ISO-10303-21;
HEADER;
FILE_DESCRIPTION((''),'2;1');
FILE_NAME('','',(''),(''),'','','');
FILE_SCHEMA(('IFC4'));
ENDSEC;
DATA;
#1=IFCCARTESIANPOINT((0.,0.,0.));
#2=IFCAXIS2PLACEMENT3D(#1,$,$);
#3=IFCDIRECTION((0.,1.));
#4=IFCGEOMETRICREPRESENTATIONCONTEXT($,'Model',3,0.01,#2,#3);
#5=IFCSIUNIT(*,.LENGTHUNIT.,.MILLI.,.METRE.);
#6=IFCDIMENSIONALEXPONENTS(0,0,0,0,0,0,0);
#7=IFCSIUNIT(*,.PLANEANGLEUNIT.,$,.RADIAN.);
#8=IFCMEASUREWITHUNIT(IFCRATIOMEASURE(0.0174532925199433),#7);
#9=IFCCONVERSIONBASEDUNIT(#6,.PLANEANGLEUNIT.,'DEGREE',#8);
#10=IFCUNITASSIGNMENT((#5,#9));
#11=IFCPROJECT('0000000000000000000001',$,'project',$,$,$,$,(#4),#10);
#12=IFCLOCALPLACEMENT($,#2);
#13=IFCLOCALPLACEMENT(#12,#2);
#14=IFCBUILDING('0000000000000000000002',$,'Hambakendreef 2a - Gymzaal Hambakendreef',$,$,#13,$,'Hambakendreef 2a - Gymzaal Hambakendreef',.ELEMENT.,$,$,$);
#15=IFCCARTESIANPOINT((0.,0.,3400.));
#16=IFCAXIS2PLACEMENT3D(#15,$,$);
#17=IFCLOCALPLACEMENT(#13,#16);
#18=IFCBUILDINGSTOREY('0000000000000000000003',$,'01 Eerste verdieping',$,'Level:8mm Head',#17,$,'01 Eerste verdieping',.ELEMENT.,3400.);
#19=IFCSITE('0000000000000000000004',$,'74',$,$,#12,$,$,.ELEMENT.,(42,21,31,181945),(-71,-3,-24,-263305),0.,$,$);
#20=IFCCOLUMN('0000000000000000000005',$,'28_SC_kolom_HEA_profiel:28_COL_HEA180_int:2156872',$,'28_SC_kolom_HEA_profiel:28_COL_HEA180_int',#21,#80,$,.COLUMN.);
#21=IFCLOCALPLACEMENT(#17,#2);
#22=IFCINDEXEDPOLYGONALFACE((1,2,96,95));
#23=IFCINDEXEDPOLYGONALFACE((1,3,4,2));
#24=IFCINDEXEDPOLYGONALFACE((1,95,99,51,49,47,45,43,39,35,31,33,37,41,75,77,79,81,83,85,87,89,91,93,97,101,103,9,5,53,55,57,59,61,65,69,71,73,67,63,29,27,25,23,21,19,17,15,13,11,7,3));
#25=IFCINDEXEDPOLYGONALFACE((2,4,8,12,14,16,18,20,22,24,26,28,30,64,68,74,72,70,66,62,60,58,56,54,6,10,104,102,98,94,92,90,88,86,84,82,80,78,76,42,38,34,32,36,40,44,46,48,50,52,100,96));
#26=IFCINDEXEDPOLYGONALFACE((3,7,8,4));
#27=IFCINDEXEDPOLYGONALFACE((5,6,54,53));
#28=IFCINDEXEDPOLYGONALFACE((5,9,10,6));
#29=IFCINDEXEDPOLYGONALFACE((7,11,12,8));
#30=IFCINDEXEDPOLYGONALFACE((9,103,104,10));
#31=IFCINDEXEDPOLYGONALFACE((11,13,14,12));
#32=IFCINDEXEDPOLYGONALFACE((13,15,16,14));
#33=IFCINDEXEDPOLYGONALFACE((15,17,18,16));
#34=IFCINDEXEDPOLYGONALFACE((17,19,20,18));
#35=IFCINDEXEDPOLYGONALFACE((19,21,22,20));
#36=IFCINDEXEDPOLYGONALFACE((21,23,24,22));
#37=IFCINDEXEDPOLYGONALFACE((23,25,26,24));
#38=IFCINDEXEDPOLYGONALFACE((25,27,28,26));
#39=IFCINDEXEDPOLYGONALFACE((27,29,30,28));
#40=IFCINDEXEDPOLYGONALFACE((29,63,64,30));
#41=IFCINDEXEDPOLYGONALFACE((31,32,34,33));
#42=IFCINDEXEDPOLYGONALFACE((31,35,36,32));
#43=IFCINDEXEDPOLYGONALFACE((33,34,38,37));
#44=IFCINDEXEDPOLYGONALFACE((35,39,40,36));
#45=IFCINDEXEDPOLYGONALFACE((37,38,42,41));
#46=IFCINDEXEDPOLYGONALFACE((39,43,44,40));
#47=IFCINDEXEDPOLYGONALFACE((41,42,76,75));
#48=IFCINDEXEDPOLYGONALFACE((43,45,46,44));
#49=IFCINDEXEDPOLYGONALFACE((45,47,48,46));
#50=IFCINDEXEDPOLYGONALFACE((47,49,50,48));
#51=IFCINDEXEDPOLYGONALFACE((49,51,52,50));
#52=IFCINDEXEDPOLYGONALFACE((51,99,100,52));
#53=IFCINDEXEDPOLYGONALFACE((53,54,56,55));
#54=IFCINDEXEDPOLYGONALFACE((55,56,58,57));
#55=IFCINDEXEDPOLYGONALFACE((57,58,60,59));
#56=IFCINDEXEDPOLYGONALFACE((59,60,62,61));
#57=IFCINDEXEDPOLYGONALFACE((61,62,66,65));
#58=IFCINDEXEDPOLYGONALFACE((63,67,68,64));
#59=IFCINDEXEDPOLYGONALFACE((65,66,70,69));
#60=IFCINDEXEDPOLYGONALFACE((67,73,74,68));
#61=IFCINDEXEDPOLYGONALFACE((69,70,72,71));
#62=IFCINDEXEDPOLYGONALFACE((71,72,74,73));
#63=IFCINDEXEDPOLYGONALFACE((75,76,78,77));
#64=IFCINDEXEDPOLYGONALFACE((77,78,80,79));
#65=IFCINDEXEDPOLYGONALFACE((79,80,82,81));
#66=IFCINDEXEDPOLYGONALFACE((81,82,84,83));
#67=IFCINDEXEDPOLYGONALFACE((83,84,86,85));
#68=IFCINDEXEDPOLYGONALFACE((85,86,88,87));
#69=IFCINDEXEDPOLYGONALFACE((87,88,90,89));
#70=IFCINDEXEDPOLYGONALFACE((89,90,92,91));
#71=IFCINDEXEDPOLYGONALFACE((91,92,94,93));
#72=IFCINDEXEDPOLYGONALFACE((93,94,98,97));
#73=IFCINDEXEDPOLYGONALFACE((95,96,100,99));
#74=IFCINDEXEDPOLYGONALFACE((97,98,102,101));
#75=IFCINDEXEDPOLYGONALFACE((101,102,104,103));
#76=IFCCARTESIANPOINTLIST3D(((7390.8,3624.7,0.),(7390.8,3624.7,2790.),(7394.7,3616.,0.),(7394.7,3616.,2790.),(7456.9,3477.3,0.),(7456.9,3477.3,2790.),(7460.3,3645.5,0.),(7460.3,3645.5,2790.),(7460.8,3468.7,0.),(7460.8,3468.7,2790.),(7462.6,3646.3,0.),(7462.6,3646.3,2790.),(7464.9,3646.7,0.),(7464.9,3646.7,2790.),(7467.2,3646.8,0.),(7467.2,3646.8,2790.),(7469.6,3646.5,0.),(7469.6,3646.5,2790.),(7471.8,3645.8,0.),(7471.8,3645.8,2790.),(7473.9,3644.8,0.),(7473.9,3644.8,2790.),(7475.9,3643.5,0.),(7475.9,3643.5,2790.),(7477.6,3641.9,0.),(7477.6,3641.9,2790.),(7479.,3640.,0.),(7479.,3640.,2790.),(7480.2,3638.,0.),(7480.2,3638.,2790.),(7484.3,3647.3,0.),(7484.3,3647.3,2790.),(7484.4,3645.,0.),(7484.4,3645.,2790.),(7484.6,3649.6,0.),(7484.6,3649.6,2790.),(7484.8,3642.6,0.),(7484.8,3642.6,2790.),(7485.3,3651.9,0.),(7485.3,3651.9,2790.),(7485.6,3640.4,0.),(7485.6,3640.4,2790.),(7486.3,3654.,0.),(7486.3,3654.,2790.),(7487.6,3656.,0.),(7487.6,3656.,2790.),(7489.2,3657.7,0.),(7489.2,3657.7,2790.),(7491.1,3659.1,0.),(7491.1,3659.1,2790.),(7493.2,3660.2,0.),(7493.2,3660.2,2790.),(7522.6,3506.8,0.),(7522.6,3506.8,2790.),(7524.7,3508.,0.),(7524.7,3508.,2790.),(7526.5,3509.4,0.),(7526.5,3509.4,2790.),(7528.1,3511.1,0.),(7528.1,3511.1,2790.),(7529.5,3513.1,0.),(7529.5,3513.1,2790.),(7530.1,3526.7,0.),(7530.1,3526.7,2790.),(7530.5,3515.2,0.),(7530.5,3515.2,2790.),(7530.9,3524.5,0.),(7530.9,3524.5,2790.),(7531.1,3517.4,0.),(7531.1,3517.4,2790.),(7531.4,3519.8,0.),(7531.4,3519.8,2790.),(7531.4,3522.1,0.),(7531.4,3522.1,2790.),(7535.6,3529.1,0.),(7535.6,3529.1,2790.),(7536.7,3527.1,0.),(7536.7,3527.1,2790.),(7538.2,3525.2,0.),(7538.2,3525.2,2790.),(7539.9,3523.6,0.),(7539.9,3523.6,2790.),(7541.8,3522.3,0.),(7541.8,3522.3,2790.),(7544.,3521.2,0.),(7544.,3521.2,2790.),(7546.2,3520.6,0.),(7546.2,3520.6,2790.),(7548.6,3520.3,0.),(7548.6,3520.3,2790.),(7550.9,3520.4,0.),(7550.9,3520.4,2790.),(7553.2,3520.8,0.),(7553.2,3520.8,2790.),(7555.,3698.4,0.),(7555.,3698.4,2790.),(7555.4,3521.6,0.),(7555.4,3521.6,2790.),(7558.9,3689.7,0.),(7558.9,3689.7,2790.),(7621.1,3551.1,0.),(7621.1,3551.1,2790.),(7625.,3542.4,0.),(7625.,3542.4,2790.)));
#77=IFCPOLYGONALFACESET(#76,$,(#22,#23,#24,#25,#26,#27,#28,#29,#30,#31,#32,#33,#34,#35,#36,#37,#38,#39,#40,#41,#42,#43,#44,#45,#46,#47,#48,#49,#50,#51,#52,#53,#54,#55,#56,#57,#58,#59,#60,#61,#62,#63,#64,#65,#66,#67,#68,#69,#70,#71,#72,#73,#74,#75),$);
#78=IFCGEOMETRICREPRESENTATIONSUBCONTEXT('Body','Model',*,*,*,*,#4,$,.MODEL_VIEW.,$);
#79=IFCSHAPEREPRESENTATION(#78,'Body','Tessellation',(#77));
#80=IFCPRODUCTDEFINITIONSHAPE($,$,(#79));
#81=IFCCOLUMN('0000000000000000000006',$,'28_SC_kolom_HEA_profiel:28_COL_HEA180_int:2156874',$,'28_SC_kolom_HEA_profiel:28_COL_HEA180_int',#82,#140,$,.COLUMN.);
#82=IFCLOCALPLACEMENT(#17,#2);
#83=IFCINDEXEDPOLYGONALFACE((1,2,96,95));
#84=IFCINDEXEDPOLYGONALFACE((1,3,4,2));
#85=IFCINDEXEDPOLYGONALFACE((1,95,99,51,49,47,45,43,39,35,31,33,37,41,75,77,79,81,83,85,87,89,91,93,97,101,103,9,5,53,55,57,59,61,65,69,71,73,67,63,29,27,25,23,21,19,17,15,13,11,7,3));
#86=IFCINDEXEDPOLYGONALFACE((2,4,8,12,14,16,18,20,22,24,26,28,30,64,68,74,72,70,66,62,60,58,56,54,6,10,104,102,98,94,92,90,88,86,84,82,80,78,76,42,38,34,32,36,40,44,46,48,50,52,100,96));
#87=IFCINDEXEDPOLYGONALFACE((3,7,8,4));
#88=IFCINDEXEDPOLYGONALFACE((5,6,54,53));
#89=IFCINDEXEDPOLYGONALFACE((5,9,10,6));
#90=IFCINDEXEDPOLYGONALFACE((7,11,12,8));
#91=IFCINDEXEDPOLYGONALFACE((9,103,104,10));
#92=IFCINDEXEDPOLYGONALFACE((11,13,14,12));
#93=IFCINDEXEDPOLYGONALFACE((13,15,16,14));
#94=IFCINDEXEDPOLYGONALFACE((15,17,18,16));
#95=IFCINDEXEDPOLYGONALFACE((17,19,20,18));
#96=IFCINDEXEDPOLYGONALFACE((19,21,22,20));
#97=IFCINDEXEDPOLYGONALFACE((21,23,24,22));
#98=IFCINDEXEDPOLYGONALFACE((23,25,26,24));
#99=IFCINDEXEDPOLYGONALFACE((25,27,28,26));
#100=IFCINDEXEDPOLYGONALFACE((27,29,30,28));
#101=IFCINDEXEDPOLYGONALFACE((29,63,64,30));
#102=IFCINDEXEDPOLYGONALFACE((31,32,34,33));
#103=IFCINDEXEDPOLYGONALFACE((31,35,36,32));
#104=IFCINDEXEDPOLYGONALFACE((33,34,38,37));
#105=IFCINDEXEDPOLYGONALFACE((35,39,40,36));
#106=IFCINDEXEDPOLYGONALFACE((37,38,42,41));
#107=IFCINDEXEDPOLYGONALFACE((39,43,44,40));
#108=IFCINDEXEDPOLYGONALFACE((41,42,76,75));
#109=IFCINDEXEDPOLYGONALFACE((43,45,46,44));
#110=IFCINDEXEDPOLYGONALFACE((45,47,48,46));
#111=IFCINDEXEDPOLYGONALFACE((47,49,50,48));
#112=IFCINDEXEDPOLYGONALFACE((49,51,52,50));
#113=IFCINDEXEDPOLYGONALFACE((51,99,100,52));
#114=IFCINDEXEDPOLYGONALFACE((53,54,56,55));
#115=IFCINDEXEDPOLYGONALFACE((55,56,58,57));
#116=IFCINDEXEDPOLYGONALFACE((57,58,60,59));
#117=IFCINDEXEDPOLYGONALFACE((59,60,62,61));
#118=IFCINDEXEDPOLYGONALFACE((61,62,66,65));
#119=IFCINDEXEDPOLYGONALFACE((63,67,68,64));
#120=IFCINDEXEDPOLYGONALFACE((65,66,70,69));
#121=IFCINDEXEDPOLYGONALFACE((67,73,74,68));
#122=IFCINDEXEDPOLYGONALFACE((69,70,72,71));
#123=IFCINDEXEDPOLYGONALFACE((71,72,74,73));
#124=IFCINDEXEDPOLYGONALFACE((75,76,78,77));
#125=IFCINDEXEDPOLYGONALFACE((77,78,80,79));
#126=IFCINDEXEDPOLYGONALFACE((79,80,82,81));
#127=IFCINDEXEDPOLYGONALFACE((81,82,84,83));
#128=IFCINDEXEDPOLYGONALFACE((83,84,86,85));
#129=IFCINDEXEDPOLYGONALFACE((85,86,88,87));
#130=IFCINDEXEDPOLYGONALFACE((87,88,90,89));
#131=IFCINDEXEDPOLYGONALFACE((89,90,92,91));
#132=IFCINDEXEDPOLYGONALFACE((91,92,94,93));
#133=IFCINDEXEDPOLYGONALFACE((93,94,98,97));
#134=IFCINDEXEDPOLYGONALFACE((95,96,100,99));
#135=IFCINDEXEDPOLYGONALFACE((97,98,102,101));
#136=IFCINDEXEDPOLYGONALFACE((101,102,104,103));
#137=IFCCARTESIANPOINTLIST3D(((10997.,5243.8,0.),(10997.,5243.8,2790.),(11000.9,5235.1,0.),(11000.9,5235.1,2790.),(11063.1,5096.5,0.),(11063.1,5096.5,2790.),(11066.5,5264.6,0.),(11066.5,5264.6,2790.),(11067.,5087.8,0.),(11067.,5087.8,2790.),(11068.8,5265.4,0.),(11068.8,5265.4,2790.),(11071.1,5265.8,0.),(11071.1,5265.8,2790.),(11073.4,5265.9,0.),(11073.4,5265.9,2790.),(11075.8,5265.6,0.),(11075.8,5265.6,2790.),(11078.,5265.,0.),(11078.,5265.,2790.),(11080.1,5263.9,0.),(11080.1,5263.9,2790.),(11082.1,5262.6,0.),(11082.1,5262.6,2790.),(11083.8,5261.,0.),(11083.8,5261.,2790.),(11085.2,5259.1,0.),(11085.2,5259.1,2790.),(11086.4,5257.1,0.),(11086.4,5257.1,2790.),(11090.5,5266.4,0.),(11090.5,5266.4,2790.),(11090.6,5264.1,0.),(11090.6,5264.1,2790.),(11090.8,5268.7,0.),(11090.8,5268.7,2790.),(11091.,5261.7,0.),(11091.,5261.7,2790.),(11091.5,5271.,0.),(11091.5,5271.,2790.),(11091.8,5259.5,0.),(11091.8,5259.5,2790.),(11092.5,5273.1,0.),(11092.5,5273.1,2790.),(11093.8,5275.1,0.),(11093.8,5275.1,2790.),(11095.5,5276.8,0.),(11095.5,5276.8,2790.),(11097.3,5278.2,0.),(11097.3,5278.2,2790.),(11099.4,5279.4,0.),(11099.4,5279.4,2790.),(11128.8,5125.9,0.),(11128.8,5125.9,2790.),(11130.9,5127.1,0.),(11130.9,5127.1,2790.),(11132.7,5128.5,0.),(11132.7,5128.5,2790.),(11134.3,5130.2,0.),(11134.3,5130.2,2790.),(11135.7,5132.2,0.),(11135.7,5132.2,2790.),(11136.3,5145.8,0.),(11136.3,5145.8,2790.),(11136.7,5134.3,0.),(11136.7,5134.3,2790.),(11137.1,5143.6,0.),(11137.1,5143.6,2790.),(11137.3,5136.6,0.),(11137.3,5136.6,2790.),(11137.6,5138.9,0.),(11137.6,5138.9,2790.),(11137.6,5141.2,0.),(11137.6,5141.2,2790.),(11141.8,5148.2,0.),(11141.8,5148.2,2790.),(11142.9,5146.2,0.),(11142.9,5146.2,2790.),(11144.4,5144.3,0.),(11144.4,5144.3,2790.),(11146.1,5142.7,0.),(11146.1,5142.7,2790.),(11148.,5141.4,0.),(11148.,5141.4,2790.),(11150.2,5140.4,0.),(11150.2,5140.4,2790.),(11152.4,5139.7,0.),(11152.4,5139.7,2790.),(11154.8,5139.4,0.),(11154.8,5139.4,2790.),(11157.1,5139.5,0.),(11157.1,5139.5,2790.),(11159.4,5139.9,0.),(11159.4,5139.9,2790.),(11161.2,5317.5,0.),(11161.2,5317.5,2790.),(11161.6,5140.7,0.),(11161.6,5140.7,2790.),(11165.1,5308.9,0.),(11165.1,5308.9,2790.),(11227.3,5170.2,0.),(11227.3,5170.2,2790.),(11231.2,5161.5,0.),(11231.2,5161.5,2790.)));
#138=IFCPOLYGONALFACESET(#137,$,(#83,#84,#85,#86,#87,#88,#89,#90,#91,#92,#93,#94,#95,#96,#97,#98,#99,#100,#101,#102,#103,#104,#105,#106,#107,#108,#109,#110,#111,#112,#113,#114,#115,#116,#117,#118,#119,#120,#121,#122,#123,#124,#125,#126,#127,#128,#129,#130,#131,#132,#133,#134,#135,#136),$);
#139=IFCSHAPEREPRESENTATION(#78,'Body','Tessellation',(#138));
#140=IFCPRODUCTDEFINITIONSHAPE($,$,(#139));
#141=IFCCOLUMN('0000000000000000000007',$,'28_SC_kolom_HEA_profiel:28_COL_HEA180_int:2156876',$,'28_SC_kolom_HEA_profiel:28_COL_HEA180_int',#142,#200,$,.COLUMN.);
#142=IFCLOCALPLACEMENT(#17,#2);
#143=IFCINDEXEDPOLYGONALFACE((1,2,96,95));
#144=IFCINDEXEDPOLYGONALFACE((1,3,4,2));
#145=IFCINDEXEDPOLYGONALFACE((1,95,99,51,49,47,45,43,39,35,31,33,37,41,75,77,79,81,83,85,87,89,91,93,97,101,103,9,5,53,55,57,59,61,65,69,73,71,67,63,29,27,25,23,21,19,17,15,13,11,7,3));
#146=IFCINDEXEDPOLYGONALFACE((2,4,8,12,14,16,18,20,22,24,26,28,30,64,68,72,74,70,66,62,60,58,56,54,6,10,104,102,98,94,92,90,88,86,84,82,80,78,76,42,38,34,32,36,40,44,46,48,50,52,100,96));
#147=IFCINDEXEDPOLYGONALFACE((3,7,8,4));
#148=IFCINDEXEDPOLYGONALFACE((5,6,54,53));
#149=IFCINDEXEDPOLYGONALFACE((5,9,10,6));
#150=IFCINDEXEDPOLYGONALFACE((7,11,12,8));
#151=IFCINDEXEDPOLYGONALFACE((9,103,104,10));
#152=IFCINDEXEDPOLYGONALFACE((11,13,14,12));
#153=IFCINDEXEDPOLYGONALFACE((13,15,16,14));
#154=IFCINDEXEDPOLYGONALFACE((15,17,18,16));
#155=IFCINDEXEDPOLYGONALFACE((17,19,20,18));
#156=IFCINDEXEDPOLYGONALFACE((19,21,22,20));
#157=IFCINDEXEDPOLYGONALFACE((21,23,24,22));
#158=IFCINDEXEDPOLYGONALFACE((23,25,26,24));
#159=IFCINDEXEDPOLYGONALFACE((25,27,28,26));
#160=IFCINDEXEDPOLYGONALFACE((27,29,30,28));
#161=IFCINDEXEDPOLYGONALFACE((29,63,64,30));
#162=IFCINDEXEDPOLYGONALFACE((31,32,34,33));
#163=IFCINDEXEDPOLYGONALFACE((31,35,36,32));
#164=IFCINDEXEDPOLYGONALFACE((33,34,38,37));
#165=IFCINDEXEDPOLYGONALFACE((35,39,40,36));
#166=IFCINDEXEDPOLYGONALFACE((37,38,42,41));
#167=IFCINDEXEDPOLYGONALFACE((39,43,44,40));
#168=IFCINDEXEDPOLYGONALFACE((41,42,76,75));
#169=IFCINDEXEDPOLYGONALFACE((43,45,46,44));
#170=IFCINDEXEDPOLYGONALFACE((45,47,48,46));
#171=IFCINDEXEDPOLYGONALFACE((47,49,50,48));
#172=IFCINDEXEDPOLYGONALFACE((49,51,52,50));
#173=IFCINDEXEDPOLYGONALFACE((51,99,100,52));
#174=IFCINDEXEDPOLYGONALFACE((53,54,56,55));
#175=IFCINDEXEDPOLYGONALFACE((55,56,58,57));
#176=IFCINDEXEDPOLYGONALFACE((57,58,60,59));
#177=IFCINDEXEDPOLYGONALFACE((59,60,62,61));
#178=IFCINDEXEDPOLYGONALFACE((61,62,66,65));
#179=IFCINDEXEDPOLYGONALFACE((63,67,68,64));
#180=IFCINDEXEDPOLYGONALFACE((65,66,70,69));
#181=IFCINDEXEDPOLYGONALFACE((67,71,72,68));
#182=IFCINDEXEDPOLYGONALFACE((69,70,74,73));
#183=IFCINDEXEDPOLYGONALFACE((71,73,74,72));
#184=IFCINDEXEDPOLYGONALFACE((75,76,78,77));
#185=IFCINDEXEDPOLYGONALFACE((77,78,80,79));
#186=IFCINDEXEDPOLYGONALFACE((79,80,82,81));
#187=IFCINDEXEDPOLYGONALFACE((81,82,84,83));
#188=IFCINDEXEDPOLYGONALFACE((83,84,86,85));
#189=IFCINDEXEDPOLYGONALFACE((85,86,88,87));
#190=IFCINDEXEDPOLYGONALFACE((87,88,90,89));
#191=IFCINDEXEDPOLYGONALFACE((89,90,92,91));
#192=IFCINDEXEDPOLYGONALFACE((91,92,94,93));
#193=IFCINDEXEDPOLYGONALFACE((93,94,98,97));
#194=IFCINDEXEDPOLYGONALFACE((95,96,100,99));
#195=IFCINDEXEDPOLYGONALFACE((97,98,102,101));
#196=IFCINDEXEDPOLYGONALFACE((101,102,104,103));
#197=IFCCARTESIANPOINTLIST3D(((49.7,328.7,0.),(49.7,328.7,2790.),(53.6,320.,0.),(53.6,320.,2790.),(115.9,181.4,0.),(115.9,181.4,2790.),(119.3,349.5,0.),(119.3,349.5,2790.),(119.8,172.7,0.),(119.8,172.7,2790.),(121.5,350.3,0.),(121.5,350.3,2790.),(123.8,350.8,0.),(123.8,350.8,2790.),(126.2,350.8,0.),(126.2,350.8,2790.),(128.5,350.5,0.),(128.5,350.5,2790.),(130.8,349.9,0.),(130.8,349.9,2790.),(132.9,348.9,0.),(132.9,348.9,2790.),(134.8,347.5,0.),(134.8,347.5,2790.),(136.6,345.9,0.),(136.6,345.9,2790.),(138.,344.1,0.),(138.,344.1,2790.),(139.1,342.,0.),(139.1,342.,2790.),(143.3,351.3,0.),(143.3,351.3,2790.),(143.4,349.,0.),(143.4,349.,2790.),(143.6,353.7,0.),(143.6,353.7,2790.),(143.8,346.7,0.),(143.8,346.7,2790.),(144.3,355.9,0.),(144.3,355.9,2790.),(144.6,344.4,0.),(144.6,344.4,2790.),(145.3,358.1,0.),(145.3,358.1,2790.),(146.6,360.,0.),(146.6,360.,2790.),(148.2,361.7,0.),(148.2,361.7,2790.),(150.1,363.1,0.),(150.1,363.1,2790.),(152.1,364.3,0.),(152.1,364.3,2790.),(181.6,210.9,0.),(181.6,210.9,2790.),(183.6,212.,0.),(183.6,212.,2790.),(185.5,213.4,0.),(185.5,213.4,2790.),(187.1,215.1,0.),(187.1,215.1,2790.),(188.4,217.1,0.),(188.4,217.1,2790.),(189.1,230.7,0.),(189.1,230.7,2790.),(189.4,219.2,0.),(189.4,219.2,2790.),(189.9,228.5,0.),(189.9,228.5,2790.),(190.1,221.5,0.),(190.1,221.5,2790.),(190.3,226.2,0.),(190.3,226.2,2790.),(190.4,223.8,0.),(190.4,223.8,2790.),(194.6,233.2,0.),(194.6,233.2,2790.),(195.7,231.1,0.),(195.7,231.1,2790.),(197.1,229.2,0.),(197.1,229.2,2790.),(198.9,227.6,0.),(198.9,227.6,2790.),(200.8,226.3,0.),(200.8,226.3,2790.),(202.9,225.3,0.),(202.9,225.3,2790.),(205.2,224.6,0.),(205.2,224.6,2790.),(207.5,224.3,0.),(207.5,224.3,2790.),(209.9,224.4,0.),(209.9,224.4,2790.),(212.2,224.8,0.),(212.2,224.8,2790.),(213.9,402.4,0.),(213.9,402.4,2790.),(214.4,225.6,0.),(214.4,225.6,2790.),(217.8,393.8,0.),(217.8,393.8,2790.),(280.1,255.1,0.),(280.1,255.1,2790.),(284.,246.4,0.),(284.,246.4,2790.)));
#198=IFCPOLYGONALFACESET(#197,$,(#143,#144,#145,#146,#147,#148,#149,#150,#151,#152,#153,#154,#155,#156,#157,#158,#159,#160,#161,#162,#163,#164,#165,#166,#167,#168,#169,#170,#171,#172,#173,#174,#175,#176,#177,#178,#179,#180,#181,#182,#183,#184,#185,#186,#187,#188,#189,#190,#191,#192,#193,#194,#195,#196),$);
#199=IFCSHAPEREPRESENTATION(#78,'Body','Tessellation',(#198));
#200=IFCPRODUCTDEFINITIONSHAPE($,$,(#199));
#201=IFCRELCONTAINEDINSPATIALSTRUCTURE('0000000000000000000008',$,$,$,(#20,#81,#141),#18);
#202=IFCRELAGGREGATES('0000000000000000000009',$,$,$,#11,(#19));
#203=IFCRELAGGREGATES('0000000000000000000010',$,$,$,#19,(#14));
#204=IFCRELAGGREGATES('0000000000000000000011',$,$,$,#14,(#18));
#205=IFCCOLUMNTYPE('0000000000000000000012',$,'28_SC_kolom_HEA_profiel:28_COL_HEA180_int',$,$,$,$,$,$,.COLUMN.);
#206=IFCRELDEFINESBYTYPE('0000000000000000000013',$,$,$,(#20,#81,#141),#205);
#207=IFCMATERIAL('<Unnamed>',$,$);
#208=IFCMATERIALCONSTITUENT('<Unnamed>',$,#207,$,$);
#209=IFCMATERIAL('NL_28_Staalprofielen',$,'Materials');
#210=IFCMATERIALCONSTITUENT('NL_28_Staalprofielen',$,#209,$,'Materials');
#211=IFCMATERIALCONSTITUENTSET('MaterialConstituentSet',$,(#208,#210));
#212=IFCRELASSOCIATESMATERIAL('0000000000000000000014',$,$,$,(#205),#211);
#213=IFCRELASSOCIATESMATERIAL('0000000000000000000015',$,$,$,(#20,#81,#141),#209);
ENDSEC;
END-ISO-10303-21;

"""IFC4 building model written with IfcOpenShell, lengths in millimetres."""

from ifc_helpers import new_model, entity, si_unit, converted_unit, direction, frame, origin, place, context, subcontext, project, spatial, indexed_curve, outline, extrude, source, transform, mapped, material, constituent, constituent_set, type_object, type_shapes, element, save


model = new_model("IFC4")

# Units and contexts
model_context = context("Model", 3, precision=0.01, world=origin(), true_north=direction((0.0, 1.0)))
body_context = subcontext(model_context, "Body", "Model", "MODEL_VIEW")
ifc_project = project(units=[si_unit("LENGTHUNIT", "METRE", prefix="MILLI"), converted_unit("PLANEANGLEUNIT", "DEGREE", entity("IfcRatioMeasure", 0.0174532925199433), si_unit("PLANEANGLEUNIT", "RADIAN"), dimensions=[0, 0, 0, 0, 0, 0, 0])], contexts=[model_context])

# Site, building, storey
site_placement = place(None, origin())
site = spatial("IfcSite", under=ifc_project, at=site_placement, Name="74", CompositionType="ELEMENT", RefLatitude=(42, 21, 31, 181945), RefLongitude=(-71, -3, -24, -263305), RefElevation=0.0)
building_placement = place(site_placement, origin())
building = spatial("IfcBuilding", under=site, at=building_placement, Name="Hambakendreef 2a - Gymzaal Hambakendreef", LongName="Hambakendreef 2a - Gymzaal Hambakendreef", CompositionType="ELEMENT")
storey_placement = place(building_placement, frame((0.0, 0.0, 3400.0)))
storey = spatial("IfcBuildingStorey", under=building, at=storey_placement, Name="01 Eerste verdieping", ObjectType="Level:8mm Head", LongName="01 Eerste verdieping", CompositionType="ELEMENT", Elevation=3400.0)

# Columns
ifc_material_1 = material(Name="NL_28_Staalprofielen", Category="Materials")
ifc_material_2 = material(Name="<Unnamed>")
ifc_constituent_1 = constituent(ifc_material_2, Name="<Unnamed>")
ifc_constituent_2 = constituent(ifc_material_1, Name="NL_28_Staalprofielen", Category="Materials")
ifc_constituent_set_1 = constituent_set(constituents=[ifc_constituent_1, ifc_constituent_2], Name="MaterialConstituentSet")
column_type_1 = type_object("IfcColumnType", Name="28_SC_kolom_HEA_profiel:28_COL_HEA180_int", PredefinedType="COLUMN", material=ifc_constituent_set_1)
shared_shape_1 = source(origin(), body_context, "Body", "SweptSolid", [
    extrude(outline(indexed_curve([(76.0, -90.0), (85.5, -90.0), (85.5, 90.0), (76.0, 90.0), (76.0, 18.0), (75.8, 15.7), (75.3, 13.4), (74.4, 11.2), (73.1, 9.2), (71.6, 7.4), (69.8, 5.9), (67.8, 4.6), (65.6, 3.7), (63.3, 3.2), (61.0, 3.0), (-61.0, 3.0), (-63.3, 3.2), (-65.6, 3.7), (-67.8, 4.6), (-69.8, 5.9), (-71.6, 7.4), (-73.1, 9.2), (-74.4, 11.2), (-75.3, 13.4), (-75.8, 15.7), (-76.0, 18.0), (-76.0, 90.0), (-85.5, 90.0), (-85.5, -90.0), (-76.0, -90.0), (-76.0, -18.0), (-75.8, -15.7), (-75.3, -13.4), (-74.4, -11.2), (-73.1, -9.2), (-71.6, -7.4), (-69.8, -5.9), (-67.8, -4.6), (-65.6, -3.7), (-63.3, -3.2), (-61.0, -3.0), (61.0, -3.0), (63.3, -3.2), (65.6, -3.7), (67.8, -4.6), (69.8, -5.9), (71.6, -7.4), (73.1, -9.2), (74.4, -11.2), (75.3, -13.4), (75.8, -15.7), (76.0, -18.0), (76.0, -90.0)], self_intersect=False)), frame((0.0, 0.0, 3400.0), z_axis=(0.0, 0.0, 1.0), x_axis=(0.0, -1.0, 0.0)), (0.0, 0.0, 1.0), 2790.0),
])
type_shapes(column_type_1, [shared_shape_1])
for number, where, z_axis, x_axis, name in (
    (1, (7507.9, 3583.5, -3400.0), (0.0, 0.0, 1.0), (0.91227, 0.40959, 0.0), "28_SC_kolom_HEA_profiel:28_COL_HEA180_int:2156872"),
    (2, (11114.1, 5202.7, -3400.0), (0.0, 0.0, 1.0), (0.91227, 0.40959, 0.0), "28_SC_kolom_HEA_profiel:28_COL_HEA180_int:2156874"),
    (3, (166.9, 287.6, -3400.0), (0.0, 0.0, 1.0), (0.91227, 0.40959, 0.0), "28_SC_kolom_HEA_profiel:28_COL_HEA180_int:2156876"),
):
    element("IfcColumn", number, at=place(storey_placement, frame(where, z_axis=z_axis, x_axis=x_axis)), inside=storey, type_object=column_type_1, material=ifc_material_1, Name=name, ObjectType="28_SC_kolom_HEA_profiel:28_COL_HEA180_int", PredefinedType="COLUMN", context=body_context, shape_type="MappedRepresentation", body=[
        mapped(shared_shape_1, transform((0.0, 0.0, 0.0), scale=1.0)),
    ])

save(model, "model.ifc")
